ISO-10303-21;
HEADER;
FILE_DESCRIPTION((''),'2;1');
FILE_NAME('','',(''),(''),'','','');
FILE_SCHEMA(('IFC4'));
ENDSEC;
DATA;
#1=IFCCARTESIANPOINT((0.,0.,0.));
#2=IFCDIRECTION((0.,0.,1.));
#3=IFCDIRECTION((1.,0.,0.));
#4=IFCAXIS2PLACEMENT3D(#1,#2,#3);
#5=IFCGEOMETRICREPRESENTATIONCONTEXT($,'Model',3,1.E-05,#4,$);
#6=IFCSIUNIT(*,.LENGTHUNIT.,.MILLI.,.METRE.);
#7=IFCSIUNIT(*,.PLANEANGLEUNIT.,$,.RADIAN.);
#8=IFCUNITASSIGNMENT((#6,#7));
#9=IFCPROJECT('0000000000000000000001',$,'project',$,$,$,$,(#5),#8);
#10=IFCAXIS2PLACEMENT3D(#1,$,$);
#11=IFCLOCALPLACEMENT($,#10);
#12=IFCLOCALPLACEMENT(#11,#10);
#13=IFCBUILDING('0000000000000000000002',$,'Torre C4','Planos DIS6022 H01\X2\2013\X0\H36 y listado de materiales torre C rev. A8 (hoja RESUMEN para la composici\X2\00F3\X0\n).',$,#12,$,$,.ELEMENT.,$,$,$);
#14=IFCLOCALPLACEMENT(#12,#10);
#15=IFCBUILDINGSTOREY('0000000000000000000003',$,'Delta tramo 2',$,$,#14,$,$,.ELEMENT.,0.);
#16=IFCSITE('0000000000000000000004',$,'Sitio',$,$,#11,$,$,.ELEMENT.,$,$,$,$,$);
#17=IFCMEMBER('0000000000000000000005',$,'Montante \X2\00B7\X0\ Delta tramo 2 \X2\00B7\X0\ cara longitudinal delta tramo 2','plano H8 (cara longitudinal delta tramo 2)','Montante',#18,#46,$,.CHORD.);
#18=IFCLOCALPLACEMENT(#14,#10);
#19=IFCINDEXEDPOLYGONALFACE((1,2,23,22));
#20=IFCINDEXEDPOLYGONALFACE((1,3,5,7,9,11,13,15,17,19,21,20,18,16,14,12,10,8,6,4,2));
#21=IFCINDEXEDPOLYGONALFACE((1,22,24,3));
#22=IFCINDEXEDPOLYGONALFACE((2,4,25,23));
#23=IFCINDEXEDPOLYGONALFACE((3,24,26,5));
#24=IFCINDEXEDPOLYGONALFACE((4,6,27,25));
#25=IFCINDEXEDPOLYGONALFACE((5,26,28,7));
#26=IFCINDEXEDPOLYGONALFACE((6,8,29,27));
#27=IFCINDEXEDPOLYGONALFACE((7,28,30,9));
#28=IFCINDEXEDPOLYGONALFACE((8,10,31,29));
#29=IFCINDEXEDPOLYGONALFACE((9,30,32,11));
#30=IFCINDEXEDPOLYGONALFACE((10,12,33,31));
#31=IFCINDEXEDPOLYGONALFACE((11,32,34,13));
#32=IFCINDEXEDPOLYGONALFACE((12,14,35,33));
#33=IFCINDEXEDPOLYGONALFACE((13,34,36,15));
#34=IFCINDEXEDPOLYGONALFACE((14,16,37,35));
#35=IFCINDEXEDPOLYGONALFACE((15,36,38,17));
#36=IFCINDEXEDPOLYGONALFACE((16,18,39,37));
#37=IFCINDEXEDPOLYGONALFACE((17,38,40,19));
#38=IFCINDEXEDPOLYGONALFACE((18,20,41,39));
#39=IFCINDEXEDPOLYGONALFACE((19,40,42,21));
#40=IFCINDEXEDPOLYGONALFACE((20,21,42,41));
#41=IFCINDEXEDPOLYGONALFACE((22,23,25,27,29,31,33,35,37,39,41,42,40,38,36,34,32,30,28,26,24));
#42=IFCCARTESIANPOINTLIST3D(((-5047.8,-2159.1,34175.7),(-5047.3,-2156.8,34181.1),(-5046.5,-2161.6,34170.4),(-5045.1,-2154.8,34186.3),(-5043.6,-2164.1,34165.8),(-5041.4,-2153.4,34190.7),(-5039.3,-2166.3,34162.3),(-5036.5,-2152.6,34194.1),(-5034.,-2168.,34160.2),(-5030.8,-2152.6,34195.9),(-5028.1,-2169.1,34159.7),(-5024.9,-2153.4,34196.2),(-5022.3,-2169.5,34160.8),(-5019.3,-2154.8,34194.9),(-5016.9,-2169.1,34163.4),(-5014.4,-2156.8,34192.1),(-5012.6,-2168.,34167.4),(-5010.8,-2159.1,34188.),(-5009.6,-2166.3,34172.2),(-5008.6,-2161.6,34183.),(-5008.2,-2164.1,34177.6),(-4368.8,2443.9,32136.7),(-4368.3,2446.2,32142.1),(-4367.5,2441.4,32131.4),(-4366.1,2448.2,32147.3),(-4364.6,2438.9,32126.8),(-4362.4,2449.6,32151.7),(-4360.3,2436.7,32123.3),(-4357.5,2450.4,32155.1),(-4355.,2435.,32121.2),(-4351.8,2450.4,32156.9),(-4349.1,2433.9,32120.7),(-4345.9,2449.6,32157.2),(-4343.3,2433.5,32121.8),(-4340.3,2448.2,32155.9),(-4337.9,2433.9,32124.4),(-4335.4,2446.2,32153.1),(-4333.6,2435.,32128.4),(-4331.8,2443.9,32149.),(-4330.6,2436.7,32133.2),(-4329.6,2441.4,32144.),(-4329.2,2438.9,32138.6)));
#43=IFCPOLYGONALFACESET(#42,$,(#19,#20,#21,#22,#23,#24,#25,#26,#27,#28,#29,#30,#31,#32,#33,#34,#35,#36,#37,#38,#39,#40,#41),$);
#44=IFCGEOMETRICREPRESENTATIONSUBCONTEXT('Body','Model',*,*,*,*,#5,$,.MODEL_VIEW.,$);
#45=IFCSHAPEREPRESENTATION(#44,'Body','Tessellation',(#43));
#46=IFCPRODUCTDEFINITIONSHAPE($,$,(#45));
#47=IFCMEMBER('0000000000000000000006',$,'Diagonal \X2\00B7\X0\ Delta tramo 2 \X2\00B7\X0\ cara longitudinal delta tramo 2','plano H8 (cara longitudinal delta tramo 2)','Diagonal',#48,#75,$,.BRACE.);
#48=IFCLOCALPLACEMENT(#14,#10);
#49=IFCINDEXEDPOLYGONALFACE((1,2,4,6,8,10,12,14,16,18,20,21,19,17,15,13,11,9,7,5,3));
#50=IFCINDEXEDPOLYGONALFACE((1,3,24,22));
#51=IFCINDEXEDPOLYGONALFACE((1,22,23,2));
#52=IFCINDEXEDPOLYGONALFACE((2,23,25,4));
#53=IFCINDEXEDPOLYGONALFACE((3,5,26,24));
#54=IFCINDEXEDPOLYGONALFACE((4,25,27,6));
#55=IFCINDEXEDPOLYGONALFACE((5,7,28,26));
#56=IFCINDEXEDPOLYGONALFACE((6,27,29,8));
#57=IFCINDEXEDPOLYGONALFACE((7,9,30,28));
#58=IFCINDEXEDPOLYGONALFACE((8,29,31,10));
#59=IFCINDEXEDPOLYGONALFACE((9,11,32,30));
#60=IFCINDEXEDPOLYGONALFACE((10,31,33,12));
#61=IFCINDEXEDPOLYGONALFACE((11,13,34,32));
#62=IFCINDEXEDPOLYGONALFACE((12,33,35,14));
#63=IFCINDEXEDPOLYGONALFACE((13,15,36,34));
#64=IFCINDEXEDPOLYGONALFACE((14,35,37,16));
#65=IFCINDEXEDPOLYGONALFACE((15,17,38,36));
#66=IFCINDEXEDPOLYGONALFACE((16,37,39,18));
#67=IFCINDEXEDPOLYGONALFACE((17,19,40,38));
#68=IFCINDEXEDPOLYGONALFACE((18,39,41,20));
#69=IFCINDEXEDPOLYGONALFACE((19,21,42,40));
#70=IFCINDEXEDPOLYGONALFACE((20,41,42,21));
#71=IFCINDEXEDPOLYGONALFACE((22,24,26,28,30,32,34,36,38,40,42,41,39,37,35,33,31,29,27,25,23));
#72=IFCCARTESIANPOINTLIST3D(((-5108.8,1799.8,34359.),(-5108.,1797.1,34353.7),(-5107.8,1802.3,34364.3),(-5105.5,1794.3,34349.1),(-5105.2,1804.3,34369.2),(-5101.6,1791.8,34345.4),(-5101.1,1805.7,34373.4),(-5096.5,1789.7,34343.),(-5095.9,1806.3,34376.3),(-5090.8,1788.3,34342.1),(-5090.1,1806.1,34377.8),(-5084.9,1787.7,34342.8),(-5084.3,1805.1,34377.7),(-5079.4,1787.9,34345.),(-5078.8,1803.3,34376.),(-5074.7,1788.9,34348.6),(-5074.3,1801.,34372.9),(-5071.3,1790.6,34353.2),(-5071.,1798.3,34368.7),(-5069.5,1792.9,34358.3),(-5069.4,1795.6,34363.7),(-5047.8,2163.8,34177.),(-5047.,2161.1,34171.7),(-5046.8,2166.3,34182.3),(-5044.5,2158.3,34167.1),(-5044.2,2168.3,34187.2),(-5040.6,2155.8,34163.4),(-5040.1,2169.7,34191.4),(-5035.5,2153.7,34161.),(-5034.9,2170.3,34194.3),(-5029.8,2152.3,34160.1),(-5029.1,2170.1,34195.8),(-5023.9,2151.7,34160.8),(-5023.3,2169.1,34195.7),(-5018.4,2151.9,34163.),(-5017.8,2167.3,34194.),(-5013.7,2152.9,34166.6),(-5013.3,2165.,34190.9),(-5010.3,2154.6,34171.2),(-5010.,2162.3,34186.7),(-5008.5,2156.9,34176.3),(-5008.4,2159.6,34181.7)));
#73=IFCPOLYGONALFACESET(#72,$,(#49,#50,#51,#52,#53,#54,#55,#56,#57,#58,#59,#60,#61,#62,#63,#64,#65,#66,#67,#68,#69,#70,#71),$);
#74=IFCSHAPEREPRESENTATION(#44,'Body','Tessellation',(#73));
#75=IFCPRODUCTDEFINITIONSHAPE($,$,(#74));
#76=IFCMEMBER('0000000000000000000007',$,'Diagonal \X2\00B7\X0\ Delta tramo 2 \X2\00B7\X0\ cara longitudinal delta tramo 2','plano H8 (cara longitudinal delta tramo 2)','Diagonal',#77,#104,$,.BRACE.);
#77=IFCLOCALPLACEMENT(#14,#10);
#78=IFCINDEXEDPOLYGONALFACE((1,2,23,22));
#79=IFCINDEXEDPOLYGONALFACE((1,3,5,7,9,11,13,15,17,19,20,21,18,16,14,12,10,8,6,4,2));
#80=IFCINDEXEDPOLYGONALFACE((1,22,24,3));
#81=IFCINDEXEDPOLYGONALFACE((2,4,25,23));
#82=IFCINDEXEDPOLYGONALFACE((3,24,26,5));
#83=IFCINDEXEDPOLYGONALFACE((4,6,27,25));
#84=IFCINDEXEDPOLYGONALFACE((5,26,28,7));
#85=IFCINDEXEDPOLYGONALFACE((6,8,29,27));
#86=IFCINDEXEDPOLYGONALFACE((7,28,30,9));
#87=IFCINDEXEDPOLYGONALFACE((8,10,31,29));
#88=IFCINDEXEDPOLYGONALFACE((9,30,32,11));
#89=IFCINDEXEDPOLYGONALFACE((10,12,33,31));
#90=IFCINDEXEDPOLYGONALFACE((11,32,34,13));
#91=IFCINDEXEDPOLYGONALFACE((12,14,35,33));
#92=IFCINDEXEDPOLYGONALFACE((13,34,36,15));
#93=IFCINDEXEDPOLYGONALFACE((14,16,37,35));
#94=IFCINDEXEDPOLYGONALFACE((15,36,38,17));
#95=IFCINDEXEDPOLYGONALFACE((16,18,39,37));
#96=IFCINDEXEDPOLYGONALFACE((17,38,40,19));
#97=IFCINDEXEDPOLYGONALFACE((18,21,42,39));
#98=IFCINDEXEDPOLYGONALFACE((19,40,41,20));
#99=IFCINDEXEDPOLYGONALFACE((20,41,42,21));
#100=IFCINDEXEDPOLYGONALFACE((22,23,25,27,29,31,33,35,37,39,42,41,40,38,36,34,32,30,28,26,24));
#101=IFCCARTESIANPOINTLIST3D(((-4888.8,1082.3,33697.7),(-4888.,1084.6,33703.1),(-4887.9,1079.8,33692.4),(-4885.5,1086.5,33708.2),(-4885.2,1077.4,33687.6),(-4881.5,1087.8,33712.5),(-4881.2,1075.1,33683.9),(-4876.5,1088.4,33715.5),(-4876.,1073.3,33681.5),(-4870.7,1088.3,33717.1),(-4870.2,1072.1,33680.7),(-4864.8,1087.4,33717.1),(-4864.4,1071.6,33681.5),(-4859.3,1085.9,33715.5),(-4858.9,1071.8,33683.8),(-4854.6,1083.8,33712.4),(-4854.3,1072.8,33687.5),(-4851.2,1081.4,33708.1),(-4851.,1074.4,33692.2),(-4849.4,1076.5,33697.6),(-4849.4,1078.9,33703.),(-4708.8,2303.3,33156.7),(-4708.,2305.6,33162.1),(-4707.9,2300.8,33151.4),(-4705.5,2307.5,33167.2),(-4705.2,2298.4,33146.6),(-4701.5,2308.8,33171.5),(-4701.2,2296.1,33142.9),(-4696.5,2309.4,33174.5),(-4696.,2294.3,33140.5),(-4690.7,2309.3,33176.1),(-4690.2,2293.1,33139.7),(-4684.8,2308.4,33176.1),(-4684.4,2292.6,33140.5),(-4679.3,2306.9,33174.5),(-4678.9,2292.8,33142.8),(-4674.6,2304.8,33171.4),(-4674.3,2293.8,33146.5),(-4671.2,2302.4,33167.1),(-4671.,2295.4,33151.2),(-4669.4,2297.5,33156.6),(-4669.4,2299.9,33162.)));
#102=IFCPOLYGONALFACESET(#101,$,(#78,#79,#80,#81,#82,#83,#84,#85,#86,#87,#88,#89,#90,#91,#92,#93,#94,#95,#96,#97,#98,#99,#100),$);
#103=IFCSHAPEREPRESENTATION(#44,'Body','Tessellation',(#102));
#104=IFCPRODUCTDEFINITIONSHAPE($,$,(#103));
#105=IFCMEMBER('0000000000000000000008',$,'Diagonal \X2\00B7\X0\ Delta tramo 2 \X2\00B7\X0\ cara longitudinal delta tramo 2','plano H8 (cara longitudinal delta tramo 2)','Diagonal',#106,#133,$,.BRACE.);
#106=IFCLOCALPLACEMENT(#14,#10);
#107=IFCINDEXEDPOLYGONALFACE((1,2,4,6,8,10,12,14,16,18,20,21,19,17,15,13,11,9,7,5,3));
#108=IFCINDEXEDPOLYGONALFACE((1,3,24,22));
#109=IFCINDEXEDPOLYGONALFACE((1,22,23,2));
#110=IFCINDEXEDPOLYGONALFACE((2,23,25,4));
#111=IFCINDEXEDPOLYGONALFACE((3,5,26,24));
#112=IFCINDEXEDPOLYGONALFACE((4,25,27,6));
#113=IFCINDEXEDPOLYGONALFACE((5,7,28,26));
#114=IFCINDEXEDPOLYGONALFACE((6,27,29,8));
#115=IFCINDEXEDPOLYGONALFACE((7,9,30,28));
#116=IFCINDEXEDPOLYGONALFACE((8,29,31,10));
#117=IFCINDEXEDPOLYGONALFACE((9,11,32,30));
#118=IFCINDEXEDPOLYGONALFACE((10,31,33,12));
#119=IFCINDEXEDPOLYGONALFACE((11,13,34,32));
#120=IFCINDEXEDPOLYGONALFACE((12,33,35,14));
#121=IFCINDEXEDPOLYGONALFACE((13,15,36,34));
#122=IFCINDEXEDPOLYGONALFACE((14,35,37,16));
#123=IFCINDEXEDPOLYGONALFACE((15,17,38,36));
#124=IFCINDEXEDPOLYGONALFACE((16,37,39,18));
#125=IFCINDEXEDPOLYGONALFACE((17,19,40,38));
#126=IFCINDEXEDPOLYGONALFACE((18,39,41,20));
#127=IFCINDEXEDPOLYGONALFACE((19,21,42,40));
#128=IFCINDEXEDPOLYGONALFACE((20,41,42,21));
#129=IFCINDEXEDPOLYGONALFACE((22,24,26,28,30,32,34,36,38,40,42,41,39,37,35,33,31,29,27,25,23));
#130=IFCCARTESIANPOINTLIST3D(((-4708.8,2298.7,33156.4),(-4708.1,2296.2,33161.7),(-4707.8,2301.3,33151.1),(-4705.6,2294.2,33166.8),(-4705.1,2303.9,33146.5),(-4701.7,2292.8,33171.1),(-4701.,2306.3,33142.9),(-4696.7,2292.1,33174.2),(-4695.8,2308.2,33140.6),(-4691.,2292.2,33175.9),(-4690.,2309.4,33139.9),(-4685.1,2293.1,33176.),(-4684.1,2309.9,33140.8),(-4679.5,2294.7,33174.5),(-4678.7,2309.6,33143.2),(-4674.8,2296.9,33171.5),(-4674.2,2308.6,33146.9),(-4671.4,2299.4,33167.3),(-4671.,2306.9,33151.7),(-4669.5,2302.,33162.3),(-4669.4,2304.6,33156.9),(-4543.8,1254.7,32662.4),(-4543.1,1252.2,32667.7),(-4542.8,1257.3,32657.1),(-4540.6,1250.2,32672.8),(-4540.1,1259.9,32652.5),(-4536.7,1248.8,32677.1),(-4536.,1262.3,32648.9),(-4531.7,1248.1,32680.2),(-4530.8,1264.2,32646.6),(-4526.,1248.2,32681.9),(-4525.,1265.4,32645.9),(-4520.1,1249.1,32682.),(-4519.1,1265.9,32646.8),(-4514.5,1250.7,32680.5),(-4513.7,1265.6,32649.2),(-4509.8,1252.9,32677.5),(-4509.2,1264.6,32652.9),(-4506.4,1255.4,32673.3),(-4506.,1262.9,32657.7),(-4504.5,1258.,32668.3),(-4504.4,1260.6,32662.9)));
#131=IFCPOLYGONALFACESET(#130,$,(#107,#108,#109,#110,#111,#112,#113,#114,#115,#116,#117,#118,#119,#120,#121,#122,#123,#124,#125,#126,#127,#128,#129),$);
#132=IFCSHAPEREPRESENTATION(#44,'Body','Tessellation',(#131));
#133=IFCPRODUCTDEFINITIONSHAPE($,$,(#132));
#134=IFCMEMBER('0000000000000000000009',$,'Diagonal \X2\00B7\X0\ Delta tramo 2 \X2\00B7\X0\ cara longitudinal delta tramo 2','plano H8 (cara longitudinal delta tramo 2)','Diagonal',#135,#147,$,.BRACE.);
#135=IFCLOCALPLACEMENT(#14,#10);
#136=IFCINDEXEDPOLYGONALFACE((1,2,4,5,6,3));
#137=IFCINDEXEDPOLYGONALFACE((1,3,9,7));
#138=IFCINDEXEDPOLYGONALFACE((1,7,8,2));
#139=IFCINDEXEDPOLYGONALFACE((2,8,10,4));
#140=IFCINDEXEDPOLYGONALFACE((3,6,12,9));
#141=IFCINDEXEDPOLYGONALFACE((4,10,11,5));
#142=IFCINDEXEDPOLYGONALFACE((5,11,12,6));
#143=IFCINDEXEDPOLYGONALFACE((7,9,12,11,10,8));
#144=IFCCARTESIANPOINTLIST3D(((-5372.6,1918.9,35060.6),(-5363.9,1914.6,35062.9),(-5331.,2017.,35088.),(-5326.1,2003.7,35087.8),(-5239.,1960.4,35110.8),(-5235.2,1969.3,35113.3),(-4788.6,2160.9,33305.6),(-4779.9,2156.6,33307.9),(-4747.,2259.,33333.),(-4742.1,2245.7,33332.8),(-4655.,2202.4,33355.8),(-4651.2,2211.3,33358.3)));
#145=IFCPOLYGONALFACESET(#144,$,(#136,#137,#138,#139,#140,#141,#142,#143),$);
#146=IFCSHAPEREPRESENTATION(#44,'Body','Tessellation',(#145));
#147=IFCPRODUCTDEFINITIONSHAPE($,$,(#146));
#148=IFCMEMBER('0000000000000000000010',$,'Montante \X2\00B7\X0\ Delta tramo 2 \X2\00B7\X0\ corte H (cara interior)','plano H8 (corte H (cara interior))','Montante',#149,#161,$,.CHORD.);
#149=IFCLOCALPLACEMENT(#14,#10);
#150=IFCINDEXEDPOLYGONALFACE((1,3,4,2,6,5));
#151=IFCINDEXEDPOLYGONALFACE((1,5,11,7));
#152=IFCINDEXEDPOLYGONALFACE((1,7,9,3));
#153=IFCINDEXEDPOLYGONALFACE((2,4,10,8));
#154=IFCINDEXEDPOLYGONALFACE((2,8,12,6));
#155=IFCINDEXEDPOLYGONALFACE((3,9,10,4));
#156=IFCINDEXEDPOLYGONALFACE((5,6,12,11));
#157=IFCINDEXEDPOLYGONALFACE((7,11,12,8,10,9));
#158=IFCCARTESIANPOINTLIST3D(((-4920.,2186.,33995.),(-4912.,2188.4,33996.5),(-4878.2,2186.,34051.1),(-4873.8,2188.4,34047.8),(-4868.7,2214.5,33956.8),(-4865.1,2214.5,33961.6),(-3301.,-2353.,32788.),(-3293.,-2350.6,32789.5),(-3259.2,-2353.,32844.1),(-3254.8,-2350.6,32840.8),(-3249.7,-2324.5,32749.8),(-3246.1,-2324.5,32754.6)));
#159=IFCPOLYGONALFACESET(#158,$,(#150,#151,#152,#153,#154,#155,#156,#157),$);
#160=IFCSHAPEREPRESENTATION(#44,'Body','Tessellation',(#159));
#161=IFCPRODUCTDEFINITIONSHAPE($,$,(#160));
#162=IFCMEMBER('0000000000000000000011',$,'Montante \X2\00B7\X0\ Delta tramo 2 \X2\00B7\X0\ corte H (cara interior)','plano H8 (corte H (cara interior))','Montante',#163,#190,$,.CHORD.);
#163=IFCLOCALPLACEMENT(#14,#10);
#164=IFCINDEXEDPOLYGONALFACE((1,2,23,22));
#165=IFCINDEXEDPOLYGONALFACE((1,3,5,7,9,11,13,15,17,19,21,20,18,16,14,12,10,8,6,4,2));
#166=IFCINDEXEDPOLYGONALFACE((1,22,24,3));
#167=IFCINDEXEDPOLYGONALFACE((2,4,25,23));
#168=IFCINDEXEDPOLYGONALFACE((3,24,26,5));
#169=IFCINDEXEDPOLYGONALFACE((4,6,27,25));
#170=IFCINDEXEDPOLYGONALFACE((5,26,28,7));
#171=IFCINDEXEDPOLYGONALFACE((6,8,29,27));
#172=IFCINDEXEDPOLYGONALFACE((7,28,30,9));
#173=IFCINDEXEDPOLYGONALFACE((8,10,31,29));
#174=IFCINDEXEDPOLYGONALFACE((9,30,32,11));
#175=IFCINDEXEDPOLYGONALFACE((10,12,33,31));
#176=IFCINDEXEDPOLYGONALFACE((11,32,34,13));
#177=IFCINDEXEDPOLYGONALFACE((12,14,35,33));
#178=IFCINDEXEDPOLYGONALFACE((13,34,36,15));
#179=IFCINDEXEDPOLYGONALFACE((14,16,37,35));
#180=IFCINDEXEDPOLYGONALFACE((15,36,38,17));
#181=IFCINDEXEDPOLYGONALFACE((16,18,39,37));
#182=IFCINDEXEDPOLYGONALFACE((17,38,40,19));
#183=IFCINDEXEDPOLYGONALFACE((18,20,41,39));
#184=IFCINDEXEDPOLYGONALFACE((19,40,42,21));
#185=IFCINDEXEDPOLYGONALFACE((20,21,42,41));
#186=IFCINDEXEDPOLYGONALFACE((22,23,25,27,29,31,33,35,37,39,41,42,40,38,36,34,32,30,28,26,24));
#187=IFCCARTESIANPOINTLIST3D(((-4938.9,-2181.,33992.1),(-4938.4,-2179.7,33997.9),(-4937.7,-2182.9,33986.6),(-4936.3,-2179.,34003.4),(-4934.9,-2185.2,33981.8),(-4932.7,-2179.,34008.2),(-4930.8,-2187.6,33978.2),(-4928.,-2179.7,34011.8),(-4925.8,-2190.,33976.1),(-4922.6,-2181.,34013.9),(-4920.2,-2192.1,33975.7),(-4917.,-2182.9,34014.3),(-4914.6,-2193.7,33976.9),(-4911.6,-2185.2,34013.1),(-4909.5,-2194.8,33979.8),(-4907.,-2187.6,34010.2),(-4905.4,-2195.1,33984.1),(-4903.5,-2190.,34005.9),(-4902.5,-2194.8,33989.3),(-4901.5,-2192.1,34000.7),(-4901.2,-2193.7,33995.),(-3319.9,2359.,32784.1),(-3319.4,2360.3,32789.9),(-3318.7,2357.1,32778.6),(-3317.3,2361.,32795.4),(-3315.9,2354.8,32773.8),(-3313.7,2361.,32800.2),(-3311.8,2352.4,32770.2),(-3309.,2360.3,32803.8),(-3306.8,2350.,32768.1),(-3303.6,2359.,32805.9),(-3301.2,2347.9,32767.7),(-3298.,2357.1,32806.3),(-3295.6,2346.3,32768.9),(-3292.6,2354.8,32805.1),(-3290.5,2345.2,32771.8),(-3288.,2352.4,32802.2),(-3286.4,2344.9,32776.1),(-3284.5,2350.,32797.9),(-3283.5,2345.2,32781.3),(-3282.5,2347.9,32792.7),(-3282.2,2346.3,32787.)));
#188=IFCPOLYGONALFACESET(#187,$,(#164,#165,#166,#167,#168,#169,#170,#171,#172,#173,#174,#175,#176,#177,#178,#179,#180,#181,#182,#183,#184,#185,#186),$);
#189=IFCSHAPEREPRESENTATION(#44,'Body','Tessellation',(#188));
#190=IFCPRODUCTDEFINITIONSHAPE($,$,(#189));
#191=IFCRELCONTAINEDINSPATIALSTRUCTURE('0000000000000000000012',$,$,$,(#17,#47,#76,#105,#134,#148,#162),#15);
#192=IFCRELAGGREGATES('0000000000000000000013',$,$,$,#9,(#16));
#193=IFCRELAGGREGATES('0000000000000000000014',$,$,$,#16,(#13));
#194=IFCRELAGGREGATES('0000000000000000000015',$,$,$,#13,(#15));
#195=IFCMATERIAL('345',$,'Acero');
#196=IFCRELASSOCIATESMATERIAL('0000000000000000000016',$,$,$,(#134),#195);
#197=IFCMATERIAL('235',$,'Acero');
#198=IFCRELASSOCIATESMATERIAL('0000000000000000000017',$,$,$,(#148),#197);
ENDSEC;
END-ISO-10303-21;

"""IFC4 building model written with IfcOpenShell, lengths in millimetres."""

from ifc_helpers import new_model, si_unit, frame, frame_2d, origin, origin_with_axes, place, context, subcontext, project, spatial, circle, l_section, extrude, material, element, save


model = new_model("IFC4")

# Units and contexts
model_context = context("Model", 3, precision=1e-05, world=origin_with_axes())
body_context = subcontext(model_context, "Body", "Model", "MODEL_VIEW")
ifc_project = project(units=[si_unit("LENGTHUNIT", "METRE", prefix="MILLI"), si_unit("PLANEANGLEUNIT", "RADIAN")], contexts=[model_context])

# Site, building, storey
site_placement = place(None, origin())
site = spatial("IfcSite", under=ifc_project, at=site_placement, Name="Sitio", CompositionType="ELEMENT")
building_placement = place(site_placement, origin())
building = spatial("IfcBuilding", under=site, at=building_placement, Name="Torre C4", Description="Planos DIS6022 H01–H36 y listado de materiales torre C rev. A8 (hoja RESUMEN para la composición).", CompositionType="ELEMENT")
storey_placement = place(building_placement, origin())
storey = spatial("IfcBuildingStorey", under=building, at=storey_placement, Name="Delta tramo 2", CompositionType="ELEMENT", Elevation=0.0)

# Members
ifc_material_1 = material(Name="345", Category="Acero")
member_1_placement = place(storey_placement, frame((-4349.0, 2442.0, 32139.0), z_axis=(-0.133662, -0.906106, 0.40138), x_axis=(0.286283, -0.42305, -0.859692)))
element("IfcMember", 1, at=member_1_placement, inside=storey, Name="Montante · Delta tramo 2 · cara longitudinal delta tramo 2", Description="plano H8 (cara longitudinal delta tramo 2)", ObjectType="Montante", PredefinedType="CHORD", context=body_context, shape_type="SweptSolid", body=[
    extrude(circle(Radius=20.0), None, (0.0, 0.0, 1.0), 5080.0),
])
member_2_placement = place(storey_placement, frame((-5028.0, 2161.0, 34178.0), z_axis=(-0.148234, -0.884546, 0.442273), x_axis=(0.975269, -0.204886, -0.082896)))
element("IfcMember", 2, at=member_2_placement, inside=storey, Name="Diagonal · Delta tramo 2 · cara longitudinal delta tramo 2", Description="plano H8 (cara longitudinal delta tramo 2)", ObjectType="Diagonal", PredefinedType="BRACE", context=body_context, shape_type="SweptSolid", body=[
    extrude(circle(Radius=20.0), None, (0.0, 0.0, 1.0), 411.5),
])
member_3_placement = place(storey_placement, frame((-4689.0, 2301.0, 33158.0), z_axis=(-0.133575, -0.906081, 0.401466), x_axis=(0.981661, -0.176564, -0.071878)))
element("IfcMember", 3, at=member_3_placement, inside=storey, Name="Diagonal · Delta tramo 2 · cara longitudinal delta tramo 2", Description="plano H8 (cara longitudinal delta tramo 2)", ObjectType="Diagonal", PredefinedType="BRACE", context=body_context, shape_type="SweptSolid", body=[
    extrude(circle(Radius=20.0), None, (0.0, 0.0, 1.0), 1347.6),
])
member_4_placement = place(storey_placement, frame((-4524.0, 1257.0, 32664.0), z_axis=(-0.141424, 0.894829, 0.423415), x_axis=(0.975028, 0.051927, 0.215926)))
element("IfcMember", 4, at=member_4_placement, inside=storey, Name="Diagonal · Delta tramo 2 · cara longitudinal delta tramo 2", Description="plano H8 (cara longitudinal delta tramo 2)", ObjectType="Diagonal", PredefinedType="BRACE", context=body_context, shape_type="SweptSolid", body=[
    extrude(circle(Radius=20.0), None, (0.0, 0.0, 1.0), 1166.7),
])
member_5_placement = place(storey_placement, frame((-5331.0, 2017.0, 35088.0), z_axis=(0.313073, 0.129732, -0.940827), x_axis=(0.871133, -0.433819, 0.230061)))
element("IfcMember", 5, at=member_5_placement, inside=storey, material=ifc_material_1, Name="Diagonal · Delta tramo 2 · cara longitudinal delta tramo 2", Description="plano H8 (cara longitudinal delta tramo 2)", ObjectType="Diagonal", PredefinedType="BRACE", context=body_context, shape_type="SweptSolid", body=[
    extrude(l_section(Depth=110.0, Width=110.0, Thickness=10.0, at=frame_2d((55.0, 55.0))), None, (0.0, 0.0, 1.0), 1865.4),
])
ifc_material_2 = material(Name="235", Category="Acero")
member_6_placement = place(storey_placement, frame((-4920.0, 2186.0, 33995.0), z_axis=(0.325889, -0.913656, -0.242957), x_axis=(0.732497, 0.406487, -0.546092)))
element("IfcMember", 6, at=member_6_placement, inside=storey, material=ifc_material_2, Name="Montante · Delta tramo 2 · corte H (cara interior)", Description="plano H8 (corte H (cara interior))", ObjectType="Montante", PredefinedType="CHORD", context=body_context, shape_type="SweptSolid", body=[
    extrude(l_section(Depth=70.0, Width=70.0, Thickness=6.0, at=frame_2d((35.0, 35.0))), None, (0.0, 0.0, 1.0), 4968.0),
])
member_7_placement = place(storey_placement, frame((-3301.0, 2353.0, 32787.0), z_axis=(-0.325813, -0.913645, 0.243102), x_axis=(0.732271, -0.406513, -0.546376)))
element("IfcMember", 7, at=member_7_placement, inside=storey, Name="Montante · Delta tramo 2 · corte H (cara interior)", Description="plano H8 (corte H (cara interior))", ObjectType="Montante", PredefinedType="CHORD", context=body_context, shape_type="SweptSolid", body=[
    extrude(circle(Radius=20.0), None, (0.0, 0.0, 1.0), 4969.1),
])

save(model, "model.ifc")
